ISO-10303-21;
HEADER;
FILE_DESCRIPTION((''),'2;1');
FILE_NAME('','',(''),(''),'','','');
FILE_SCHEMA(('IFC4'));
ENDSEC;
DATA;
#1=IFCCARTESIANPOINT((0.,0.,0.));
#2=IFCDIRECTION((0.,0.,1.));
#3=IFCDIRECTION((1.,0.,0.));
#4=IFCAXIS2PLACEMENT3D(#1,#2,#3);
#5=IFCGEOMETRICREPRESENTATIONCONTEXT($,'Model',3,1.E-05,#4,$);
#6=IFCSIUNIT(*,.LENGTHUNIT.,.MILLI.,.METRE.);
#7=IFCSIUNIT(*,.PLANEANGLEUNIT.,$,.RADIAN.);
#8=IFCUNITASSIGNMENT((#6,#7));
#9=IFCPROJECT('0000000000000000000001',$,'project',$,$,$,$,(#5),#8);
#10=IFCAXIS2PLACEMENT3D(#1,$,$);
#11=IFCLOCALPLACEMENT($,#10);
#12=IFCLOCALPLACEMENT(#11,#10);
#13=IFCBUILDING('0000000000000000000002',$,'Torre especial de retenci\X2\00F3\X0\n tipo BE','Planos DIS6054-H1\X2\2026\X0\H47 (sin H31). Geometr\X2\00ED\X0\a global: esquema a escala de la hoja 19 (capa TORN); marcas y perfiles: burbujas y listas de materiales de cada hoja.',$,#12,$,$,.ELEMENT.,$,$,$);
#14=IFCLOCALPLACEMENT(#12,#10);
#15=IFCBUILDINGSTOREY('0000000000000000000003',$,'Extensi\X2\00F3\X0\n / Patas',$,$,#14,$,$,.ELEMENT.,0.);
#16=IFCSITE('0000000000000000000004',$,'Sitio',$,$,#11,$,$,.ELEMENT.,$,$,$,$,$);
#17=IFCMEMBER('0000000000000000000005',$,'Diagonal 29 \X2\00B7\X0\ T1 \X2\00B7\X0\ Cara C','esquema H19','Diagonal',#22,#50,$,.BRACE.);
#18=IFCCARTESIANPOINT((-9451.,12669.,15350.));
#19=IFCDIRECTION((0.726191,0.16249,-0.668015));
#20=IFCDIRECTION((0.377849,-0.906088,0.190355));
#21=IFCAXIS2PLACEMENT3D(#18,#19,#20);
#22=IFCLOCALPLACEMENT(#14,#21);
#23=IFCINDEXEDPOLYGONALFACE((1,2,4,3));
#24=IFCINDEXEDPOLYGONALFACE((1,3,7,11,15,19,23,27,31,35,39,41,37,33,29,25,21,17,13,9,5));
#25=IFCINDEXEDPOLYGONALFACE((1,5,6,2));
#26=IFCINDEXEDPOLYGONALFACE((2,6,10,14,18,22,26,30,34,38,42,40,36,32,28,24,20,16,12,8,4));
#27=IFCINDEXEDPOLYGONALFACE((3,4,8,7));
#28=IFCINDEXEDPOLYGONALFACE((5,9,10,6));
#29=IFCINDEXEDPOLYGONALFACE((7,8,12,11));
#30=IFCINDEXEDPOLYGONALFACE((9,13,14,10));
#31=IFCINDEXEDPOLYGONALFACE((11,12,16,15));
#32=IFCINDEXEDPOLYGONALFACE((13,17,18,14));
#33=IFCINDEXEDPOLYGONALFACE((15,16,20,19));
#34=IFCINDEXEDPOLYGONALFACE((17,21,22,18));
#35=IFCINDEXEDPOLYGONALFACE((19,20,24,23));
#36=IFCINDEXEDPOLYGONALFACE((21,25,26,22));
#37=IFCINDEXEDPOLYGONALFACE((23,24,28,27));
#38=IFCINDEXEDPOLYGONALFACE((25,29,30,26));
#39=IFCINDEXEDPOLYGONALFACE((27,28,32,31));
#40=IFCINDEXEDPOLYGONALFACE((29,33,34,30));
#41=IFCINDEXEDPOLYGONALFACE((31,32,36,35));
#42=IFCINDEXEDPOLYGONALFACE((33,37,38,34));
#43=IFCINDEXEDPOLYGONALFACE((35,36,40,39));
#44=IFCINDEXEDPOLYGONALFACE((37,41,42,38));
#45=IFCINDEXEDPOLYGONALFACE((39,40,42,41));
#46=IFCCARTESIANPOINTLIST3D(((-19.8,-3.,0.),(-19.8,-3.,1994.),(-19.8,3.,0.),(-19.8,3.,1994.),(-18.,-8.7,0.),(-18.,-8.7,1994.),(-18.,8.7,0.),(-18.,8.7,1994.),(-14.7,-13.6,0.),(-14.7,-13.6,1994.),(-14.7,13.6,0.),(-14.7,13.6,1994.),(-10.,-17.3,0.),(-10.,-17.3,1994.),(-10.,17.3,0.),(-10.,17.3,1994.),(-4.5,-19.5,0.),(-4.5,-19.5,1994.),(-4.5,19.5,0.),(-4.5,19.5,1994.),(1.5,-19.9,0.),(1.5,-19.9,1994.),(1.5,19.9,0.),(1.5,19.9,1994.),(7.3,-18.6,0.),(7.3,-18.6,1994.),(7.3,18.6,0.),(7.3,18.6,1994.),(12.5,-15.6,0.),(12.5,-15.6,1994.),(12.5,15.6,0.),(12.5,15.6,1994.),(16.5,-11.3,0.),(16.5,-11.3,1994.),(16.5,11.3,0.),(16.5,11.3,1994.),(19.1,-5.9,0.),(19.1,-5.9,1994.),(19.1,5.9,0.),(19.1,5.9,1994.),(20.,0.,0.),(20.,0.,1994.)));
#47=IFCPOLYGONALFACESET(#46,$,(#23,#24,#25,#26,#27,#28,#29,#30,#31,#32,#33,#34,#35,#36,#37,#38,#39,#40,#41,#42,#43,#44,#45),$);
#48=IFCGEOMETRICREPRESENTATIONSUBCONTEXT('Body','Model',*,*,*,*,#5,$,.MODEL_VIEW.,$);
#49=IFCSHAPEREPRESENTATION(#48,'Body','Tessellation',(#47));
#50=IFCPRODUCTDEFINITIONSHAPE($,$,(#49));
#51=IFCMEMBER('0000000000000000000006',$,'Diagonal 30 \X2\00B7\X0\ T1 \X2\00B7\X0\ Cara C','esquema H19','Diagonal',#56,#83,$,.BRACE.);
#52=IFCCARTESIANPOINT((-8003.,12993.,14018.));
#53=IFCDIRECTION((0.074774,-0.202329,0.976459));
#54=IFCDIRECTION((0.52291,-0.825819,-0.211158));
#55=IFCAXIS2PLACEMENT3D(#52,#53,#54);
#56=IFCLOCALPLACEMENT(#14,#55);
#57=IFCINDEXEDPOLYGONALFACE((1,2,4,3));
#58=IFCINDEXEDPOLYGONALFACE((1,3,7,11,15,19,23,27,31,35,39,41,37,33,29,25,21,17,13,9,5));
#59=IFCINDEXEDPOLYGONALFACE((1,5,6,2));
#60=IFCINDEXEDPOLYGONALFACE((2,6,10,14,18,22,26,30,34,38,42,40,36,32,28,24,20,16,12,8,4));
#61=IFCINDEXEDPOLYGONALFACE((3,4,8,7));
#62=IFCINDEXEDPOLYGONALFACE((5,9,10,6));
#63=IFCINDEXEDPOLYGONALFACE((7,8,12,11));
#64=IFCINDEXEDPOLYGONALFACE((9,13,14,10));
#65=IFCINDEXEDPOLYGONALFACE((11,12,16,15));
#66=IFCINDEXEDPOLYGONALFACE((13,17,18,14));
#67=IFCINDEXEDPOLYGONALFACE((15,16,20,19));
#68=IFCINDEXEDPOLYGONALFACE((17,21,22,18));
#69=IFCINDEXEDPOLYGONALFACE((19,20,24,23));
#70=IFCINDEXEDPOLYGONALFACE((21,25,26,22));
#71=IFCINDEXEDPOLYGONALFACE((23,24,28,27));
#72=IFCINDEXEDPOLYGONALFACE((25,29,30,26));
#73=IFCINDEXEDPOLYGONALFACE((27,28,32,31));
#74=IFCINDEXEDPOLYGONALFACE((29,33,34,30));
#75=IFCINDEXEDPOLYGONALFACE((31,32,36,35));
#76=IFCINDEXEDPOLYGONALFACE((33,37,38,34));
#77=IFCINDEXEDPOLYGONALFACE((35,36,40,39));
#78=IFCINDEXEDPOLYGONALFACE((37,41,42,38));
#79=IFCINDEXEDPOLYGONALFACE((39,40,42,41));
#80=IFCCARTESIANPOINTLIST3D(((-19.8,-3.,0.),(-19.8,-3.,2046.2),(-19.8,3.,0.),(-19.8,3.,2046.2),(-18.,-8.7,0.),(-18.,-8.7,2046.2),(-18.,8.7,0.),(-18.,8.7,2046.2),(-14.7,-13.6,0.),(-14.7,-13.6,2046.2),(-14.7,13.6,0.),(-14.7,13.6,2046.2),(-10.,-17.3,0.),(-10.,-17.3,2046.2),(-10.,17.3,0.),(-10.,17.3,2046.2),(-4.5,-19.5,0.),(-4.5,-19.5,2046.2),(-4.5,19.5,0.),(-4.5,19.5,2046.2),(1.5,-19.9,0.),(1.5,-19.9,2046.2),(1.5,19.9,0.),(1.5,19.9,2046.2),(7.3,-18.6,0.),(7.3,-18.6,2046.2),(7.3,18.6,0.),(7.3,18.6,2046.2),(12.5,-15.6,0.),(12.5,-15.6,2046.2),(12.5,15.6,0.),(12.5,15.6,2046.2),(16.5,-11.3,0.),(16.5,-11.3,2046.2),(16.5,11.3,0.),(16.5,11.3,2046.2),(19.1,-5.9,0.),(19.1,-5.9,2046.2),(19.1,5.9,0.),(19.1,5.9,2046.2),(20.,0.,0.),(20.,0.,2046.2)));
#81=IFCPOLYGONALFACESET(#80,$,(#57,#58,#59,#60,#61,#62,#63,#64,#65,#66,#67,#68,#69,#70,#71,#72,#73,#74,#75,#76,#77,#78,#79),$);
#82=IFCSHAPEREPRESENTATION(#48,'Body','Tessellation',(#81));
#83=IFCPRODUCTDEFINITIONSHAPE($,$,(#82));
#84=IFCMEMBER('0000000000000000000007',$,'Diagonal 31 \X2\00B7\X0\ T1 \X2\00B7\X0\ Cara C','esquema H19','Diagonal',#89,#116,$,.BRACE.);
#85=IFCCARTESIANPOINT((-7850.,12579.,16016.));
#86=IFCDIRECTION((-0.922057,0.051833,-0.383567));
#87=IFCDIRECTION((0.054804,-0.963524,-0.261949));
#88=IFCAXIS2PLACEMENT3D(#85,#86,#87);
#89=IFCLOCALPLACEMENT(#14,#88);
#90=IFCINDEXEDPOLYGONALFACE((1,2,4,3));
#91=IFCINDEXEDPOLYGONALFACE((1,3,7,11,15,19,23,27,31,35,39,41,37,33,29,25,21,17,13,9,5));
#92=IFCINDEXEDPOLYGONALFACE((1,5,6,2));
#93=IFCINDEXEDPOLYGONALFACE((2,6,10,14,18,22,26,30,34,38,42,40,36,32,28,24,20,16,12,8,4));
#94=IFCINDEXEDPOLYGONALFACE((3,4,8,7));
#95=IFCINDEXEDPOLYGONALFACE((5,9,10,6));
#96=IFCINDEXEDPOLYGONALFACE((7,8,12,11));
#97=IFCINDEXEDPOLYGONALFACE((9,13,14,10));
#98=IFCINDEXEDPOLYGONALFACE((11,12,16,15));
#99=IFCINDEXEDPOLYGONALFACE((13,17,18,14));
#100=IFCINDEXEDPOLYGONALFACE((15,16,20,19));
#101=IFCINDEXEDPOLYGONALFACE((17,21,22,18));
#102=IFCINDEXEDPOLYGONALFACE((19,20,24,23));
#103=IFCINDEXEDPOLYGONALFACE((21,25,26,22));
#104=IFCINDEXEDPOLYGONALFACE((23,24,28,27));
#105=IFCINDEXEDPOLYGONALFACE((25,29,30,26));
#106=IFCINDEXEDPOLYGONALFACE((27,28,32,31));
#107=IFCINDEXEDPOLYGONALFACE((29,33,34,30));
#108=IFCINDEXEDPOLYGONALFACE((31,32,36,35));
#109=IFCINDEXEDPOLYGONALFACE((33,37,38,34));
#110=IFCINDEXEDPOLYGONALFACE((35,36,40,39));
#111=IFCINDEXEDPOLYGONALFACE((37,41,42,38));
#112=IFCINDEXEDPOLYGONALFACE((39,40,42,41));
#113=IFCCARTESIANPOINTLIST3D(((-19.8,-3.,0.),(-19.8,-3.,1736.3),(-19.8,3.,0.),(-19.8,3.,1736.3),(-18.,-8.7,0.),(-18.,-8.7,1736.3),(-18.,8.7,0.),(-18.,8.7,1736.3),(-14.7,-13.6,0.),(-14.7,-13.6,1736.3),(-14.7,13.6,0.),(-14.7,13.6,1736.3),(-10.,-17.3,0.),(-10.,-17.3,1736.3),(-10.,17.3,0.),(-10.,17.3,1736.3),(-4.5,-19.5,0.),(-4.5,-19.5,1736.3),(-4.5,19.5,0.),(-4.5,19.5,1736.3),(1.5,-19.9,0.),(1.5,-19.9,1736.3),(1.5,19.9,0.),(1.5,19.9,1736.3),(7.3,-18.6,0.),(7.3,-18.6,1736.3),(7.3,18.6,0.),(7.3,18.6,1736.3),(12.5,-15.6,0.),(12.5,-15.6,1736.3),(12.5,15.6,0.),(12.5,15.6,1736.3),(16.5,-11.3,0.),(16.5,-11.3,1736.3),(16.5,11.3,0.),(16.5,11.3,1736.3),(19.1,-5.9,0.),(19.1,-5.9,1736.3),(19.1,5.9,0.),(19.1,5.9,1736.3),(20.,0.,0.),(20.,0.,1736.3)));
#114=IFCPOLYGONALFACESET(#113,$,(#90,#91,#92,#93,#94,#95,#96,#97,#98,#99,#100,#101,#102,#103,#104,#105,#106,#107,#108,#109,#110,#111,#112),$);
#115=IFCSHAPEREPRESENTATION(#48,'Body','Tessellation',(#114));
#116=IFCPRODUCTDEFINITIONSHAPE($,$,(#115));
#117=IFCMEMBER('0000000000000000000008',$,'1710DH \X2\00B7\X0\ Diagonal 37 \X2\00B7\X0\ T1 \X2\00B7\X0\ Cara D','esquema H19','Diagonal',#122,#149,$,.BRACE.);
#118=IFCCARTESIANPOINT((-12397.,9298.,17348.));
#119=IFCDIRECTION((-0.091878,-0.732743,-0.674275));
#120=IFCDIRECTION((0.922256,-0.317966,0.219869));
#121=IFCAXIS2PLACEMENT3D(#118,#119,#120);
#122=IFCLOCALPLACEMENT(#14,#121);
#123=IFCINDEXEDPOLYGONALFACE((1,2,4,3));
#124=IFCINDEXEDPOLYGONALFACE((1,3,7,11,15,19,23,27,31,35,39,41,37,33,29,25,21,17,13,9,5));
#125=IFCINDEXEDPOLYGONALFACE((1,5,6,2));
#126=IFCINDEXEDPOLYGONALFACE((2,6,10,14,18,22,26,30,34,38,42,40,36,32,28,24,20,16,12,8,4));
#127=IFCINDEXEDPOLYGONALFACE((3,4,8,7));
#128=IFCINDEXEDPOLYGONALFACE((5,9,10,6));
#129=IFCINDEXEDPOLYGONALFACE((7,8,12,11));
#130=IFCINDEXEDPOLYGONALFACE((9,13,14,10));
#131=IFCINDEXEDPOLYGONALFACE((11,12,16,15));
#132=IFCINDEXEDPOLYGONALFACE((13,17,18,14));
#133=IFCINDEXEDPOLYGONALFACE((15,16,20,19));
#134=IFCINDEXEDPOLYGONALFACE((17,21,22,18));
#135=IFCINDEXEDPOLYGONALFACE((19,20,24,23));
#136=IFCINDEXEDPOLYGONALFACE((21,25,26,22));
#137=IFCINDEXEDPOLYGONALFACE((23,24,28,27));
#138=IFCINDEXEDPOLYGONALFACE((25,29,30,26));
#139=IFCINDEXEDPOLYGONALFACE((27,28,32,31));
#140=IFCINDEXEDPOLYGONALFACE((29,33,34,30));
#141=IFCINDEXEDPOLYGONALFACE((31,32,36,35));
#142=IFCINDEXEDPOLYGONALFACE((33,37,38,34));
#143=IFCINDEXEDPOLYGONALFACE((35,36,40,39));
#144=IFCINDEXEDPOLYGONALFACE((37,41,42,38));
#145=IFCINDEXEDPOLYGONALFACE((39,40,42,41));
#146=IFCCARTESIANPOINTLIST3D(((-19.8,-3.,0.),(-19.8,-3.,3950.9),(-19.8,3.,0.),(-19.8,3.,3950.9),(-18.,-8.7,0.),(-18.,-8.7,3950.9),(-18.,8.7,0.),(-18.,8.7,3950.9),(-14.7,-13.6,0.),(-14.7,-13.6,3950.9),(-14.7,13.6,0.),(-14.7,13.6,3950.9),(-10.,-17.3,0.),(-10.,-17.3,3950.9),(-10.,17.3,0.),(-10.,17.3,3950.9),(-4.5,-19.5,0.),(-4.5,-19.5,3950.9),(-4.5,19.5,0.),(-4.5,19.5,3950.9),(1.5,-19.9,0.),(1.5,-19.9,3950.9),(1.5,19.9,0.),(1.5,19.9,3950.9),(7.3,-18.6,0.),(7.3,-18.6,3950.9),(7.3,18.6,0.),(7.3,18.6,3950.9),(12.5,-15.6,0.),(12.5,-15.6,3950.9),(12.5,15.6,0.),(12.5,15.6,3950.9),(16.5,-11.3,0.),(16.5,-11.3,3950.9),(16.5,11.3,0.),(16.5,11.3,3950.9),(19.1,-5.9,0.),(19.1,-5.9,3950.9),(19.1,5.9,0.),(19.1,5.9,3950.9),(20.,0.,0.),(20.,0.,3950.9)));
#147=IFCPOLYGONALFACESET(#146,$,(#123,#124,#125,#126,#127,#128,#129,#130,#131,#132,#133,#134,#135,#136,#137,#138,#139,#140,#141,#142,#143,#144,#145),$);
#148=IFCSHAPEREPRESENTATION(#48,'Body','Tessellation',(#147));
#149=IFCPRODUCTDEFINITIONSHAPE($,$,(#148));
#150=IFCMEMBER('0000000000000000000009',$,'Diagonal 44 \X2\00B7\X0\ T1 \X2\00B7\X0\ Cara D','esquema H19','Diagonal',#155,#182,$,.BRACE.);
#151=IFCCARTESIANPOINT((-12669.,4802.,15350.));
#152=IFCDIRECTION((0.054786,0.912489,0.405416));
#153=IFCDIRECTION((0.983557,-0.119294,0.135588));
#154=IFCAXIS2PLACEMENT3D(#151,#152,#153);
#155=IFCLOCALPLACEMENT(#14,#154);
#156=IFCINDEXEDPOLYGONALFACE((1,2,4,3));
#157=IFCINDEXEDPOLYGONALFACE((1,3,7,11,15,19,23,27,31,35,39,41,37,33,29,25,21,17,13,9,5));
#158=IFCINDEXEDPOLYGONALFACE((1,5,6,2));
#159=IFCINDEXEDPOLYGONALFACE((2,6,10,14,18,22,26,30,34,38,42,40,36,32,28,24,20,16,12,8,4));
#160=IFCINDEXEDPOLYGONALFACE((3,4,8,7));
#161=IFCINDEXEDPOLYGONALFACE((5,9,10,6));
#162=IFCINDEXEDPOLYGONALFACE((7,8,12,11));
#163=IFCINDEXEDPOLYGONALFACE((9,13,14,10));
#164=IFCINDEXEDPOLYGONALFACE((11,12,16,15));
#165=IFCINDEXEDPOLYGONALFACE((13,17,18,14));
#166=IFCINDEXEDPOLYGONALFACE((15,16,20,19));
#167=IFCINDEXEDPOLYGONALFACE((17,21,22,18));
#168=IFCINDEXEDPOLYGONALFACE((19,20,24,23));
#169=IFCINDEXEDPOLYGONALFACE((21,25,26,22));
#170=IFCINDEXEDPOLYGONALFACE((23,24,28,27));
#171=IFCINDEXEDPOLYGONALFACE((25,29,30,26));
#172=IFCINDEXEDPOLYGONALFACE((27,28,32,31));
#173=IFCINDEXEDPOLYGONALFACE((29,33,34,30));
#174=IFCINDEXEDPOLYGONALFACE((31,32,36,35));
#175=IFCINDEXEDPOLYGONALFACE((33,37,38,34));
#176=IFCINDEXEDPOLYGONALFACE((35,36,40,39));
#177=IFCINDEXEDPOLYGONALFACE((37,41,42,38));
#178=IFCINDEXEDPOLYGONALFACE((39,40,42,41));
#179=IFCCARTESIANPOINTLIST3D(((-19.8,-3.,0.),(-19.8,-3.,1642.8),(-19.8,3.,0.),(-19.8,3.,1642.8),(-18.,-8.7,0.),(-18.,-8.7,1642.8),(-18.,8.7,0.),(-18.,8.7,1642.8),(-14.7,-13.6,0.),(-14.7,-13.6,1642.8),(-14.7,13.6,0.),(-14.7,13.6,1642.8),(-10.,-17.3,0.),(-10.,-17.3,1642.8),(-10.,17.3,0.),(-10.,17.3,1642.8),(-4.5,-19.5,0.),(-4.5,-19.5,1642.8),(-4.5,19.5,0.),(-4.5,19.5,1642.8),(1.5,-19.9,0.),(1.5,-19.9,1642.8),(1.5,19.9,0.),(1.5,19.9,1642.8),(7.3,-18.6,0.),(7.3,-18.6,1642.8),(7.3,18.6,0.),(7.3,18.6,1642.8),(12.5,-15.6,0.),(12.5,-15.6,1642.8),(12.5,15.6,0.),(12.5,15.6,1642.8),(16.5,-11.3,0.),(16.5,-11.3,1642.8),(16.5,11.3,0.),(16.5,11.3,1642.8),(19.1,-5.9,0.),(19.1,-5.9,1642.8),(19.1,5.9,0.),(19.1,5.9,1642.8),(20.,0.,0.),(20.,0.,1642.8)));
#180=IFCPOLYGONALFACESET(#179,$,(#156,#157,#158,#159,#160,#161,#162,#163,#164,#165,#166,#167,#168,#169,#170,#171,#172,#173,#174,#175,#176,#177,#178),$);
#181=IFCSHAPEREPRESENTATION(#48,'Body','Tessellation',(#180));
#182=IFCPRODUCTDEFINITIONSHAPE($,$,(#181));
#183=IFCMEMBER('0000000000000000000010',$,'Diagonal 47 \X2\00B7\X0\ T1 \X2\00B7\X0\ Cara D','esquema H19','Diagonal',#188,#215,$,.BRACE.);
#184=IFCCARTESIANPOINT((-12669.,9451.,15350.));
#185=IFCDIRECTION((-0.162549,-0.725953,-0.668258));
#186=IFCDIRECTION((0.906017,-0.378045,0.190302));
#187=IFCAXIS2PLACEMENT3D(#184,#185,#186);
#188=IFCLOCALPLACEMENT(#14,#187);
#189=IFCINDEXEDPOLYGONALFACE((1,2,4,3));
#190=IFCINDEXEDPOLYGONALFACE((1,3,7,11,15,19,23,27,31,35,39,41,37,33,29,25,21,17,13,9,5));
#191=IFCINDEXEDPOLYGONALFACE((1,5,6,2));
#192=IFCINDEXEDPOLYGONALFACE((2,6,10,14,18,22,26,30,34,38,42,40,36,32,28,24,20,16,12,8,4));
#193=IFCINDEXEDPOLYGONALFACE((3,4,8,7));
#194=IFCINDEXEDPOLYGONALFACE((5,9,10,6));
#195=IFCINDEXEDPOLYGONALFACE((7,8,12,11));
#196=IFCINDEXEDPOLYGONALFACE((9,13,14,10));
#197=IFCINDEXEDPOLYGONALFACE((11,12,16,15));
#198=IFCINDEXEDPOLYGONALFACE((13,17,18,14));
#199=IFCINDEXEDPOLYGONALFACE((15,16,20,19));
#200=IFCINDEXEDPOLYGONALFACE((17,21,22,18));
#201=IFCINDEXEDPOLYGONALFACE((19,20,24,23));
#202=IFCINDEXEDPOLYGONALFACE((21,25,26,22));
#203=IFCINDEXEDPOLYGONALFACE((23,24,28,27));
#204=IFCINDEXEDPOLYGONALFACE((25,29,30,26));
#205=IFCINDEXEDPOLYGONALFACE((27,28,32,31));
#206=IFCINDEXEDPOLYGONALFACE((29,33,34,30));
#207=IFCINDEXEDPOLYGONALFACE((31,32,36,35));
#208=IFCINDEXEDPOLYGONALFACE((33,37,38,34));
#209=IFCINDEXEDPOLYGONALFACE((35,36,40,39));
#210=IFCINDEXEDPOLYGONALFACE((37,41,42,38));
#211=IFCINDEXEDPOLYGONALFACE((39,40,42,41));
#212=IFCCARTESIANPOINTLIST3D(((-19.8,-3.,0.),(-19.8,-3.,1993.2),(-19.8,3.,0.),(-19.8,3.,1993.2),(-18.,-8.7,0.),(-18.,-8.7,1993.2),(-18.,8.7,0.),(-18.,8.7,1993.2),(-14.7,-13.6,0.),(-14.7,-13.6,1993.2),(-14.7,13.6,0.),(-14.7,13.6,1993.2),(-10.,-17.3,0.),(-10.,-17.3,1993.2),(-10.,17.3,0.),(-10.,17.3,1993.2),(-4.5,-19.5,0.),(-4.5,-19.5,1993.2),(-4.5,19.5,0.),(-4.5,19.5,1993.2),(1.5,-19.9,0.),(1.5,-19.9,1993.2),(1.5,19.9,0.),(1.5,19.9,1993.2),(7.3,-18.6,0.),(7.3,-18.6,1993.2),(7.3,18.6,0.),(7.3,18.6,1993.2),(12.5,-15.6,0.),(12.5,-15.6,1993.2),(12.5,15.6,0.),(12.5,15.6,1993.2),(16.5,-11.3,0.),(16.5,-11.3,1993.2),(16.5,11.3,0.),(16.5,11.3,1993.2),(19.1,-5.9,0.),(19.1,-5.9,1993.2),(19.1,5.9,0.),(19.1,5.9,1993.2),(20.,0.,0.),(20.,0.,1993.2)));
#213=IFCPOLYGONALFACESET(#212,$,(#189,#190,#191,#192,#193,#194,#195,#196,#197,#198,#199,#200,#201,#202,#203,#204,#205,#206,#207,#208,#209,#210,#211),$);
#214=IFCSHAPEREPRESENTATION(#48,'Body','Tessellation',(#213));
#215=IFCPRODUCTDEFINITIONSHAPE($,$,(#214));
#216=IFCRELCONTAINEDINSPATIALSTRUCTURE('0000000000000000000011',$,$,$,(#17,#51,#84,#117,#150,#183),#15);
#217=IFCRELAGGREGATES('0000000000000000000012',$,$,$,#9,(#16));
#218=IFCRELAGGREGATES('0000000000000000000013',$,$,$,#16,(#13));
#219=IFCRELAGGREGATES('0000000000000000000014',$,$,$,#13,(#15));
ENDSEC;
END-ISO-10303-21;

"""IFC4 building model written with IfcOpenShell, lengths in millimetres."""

from ifc_helpers import new_model, si_unit, frame, origin, origin_with_axes, place, context, subcontext, project, spatial, circle, extrude, element, save


model = new_model("IFC4")

# Units and contexts
model_context = context("Model", 3, precision=1e-05, world=origin_with_axes())
body_context = subcontext(model_context, "Body", "Model", "MODEL_VIEW")
ifc_project = project(units=[si_unit("LENGTHUNIT", "METRE", prefix="MILLI"), si_unit("PLANEANGLEUNIT", "RADIAN")], contexts=[model_context])

# Site, building, storey
site_placement = place(None, origin())
site = spatial("IfcSite", under=ifc_project, at=site_placement, Name="Sitio", CompositionType="ELEMENT")
building_placement = place(site_placement, origin())
building = spatial("IfcBuilding", under=site, at=building_placement, Name="Torre especial de retención tipo BE", Description="Planos DIS6054-H1…H47 (sin H31). Geometría global: esquema a escala de la hoja 19 (capa TORN); marcas y perfiles: burbujas y listas de materiales de cada hoja.", CompositionType="ELEMENT")
storey_placement = place(building_placement, origin())
storey = spatial("IfcBuildingStorey", under=building, at=storey_placement, Name="Extensión / Patas", CompositionType="ELEMENT", Elevation=0.0)

# Members
member_1_placement = place(storey_placement, frame((-9451.0, 12669.0, 15350.0), z_axis=(0.726191, 0.16249, -0.668015), x_axis=(0.377849, -0.906088, 0.190355)))
element("IfcMember", 1, at=member_1_placement, inside=storey, Name="Diagonal 29 · T1 · Cara C", Description="esquema H19", ObjectType="Diagonal", PredefinedType="BRACE", context=body_context, shape_type="SweptSolid", body=[
    extrude(circle(Radius=20.0), None, (0.0, 0.0, 1.0), 1994.0),
])
member_2_placement = place(storey_placement, frame((-8003.0, 12993.0, 14018.0), z_axis=(0.074774, -0.202329, 0.976459), x_axis=(0.52291, -0.825819, -0.211158)))
element("IfcMember", 2, at=member_2_placement, inside=storey, Name="Diagonal 30 · T1 · Cara C", Description="esquema H19", ObjectType="Diagonal", PredefinedType="BRACE", context=body_context, shape_type="SweptSolid", body=[
    extrude(circle(Radius=20.0), None, (0.0, 0.0, 1.0), 2046.2),
])
member_3_placement = place(storey_placement, frame((-7850.0, 12579.0, 16016.0), z_axis=(-0.922057, 0.051833, -0.383567), x_axis=(0.054804, -0.963524, -0.261949)))
element("IfcMember", 3, at=member_3_placement, inside=storey, Name="Diagonal 31 · T1 · Cara C", Description="esquema H19", ObjectType="Diagonal", PredefinedType="BRACE", context=body_context, shape_type="SweptSolid", body=[
    extrude(circle(Radius=20.0), None, (0.0, 0.0, 1.0), 1736.3),
])
member_4_placement = place(storey_placement, frame((-12397.0, 9298.0, 17348.0), z_axis=(-0.091878, -0.732743, -0.674275), x_axis=(0.922256, -0.317966, 0.219869)))
element("IfcMember", 4, at=member_4_placement, inside=storey, Name="1710DH · Diagonal 37 · T1 · Cara D", Description="esquema H19", ObjectType="Diagonal", PredefinedType="BRACE", context=body_context, shape_type="SweptSolid", body=[
    extrude(circle(Radius=20.0), None, (0.0, 0.0, 1.0), 3950.9),
])
member_5_placement = place(storey_placement, frame((-12669.0, 4802.0, 15350.0), z_axis=(0.054786, 0.912489, 0.405416), x_axis=(0.983557, -0.119294, 0.135588)))
element("IfcMember", 5, at=member_5_placement, inside=storey, Name="Diagonal 44 · T1 · Cara D", Description="esquema H19", ObjectType="Diagonal", PredefinedType="BRACE", context=body_context, shape_type="SweptSolid", body=[
    extrude(circle(Radius=20.0), None, (0.0, 0.0, 1.0), 1642.8),
])
member_6_placement = place(storey_placement, frame((-12669.0, 9451.0, 15350.0), z_axis=(-0.162549, -0.725953, -0.668258), x_axis=(0.906017, -0.378045, 0.190302)))
element("IfcMember", 6, at=member_6_placement, inside=storey, Name="Diagonal 47 · T1 · Cara D", Description="esquema H19", ObjectType="Diagonal", PredefinedType="BRACE", context=body_context, shape_type="SweptSolid", body=[
    extrude(circle(Radius=20.0), None, (0.0, 0.0, 1.0), 1993.2),
])

save(model, "model.ifc")
